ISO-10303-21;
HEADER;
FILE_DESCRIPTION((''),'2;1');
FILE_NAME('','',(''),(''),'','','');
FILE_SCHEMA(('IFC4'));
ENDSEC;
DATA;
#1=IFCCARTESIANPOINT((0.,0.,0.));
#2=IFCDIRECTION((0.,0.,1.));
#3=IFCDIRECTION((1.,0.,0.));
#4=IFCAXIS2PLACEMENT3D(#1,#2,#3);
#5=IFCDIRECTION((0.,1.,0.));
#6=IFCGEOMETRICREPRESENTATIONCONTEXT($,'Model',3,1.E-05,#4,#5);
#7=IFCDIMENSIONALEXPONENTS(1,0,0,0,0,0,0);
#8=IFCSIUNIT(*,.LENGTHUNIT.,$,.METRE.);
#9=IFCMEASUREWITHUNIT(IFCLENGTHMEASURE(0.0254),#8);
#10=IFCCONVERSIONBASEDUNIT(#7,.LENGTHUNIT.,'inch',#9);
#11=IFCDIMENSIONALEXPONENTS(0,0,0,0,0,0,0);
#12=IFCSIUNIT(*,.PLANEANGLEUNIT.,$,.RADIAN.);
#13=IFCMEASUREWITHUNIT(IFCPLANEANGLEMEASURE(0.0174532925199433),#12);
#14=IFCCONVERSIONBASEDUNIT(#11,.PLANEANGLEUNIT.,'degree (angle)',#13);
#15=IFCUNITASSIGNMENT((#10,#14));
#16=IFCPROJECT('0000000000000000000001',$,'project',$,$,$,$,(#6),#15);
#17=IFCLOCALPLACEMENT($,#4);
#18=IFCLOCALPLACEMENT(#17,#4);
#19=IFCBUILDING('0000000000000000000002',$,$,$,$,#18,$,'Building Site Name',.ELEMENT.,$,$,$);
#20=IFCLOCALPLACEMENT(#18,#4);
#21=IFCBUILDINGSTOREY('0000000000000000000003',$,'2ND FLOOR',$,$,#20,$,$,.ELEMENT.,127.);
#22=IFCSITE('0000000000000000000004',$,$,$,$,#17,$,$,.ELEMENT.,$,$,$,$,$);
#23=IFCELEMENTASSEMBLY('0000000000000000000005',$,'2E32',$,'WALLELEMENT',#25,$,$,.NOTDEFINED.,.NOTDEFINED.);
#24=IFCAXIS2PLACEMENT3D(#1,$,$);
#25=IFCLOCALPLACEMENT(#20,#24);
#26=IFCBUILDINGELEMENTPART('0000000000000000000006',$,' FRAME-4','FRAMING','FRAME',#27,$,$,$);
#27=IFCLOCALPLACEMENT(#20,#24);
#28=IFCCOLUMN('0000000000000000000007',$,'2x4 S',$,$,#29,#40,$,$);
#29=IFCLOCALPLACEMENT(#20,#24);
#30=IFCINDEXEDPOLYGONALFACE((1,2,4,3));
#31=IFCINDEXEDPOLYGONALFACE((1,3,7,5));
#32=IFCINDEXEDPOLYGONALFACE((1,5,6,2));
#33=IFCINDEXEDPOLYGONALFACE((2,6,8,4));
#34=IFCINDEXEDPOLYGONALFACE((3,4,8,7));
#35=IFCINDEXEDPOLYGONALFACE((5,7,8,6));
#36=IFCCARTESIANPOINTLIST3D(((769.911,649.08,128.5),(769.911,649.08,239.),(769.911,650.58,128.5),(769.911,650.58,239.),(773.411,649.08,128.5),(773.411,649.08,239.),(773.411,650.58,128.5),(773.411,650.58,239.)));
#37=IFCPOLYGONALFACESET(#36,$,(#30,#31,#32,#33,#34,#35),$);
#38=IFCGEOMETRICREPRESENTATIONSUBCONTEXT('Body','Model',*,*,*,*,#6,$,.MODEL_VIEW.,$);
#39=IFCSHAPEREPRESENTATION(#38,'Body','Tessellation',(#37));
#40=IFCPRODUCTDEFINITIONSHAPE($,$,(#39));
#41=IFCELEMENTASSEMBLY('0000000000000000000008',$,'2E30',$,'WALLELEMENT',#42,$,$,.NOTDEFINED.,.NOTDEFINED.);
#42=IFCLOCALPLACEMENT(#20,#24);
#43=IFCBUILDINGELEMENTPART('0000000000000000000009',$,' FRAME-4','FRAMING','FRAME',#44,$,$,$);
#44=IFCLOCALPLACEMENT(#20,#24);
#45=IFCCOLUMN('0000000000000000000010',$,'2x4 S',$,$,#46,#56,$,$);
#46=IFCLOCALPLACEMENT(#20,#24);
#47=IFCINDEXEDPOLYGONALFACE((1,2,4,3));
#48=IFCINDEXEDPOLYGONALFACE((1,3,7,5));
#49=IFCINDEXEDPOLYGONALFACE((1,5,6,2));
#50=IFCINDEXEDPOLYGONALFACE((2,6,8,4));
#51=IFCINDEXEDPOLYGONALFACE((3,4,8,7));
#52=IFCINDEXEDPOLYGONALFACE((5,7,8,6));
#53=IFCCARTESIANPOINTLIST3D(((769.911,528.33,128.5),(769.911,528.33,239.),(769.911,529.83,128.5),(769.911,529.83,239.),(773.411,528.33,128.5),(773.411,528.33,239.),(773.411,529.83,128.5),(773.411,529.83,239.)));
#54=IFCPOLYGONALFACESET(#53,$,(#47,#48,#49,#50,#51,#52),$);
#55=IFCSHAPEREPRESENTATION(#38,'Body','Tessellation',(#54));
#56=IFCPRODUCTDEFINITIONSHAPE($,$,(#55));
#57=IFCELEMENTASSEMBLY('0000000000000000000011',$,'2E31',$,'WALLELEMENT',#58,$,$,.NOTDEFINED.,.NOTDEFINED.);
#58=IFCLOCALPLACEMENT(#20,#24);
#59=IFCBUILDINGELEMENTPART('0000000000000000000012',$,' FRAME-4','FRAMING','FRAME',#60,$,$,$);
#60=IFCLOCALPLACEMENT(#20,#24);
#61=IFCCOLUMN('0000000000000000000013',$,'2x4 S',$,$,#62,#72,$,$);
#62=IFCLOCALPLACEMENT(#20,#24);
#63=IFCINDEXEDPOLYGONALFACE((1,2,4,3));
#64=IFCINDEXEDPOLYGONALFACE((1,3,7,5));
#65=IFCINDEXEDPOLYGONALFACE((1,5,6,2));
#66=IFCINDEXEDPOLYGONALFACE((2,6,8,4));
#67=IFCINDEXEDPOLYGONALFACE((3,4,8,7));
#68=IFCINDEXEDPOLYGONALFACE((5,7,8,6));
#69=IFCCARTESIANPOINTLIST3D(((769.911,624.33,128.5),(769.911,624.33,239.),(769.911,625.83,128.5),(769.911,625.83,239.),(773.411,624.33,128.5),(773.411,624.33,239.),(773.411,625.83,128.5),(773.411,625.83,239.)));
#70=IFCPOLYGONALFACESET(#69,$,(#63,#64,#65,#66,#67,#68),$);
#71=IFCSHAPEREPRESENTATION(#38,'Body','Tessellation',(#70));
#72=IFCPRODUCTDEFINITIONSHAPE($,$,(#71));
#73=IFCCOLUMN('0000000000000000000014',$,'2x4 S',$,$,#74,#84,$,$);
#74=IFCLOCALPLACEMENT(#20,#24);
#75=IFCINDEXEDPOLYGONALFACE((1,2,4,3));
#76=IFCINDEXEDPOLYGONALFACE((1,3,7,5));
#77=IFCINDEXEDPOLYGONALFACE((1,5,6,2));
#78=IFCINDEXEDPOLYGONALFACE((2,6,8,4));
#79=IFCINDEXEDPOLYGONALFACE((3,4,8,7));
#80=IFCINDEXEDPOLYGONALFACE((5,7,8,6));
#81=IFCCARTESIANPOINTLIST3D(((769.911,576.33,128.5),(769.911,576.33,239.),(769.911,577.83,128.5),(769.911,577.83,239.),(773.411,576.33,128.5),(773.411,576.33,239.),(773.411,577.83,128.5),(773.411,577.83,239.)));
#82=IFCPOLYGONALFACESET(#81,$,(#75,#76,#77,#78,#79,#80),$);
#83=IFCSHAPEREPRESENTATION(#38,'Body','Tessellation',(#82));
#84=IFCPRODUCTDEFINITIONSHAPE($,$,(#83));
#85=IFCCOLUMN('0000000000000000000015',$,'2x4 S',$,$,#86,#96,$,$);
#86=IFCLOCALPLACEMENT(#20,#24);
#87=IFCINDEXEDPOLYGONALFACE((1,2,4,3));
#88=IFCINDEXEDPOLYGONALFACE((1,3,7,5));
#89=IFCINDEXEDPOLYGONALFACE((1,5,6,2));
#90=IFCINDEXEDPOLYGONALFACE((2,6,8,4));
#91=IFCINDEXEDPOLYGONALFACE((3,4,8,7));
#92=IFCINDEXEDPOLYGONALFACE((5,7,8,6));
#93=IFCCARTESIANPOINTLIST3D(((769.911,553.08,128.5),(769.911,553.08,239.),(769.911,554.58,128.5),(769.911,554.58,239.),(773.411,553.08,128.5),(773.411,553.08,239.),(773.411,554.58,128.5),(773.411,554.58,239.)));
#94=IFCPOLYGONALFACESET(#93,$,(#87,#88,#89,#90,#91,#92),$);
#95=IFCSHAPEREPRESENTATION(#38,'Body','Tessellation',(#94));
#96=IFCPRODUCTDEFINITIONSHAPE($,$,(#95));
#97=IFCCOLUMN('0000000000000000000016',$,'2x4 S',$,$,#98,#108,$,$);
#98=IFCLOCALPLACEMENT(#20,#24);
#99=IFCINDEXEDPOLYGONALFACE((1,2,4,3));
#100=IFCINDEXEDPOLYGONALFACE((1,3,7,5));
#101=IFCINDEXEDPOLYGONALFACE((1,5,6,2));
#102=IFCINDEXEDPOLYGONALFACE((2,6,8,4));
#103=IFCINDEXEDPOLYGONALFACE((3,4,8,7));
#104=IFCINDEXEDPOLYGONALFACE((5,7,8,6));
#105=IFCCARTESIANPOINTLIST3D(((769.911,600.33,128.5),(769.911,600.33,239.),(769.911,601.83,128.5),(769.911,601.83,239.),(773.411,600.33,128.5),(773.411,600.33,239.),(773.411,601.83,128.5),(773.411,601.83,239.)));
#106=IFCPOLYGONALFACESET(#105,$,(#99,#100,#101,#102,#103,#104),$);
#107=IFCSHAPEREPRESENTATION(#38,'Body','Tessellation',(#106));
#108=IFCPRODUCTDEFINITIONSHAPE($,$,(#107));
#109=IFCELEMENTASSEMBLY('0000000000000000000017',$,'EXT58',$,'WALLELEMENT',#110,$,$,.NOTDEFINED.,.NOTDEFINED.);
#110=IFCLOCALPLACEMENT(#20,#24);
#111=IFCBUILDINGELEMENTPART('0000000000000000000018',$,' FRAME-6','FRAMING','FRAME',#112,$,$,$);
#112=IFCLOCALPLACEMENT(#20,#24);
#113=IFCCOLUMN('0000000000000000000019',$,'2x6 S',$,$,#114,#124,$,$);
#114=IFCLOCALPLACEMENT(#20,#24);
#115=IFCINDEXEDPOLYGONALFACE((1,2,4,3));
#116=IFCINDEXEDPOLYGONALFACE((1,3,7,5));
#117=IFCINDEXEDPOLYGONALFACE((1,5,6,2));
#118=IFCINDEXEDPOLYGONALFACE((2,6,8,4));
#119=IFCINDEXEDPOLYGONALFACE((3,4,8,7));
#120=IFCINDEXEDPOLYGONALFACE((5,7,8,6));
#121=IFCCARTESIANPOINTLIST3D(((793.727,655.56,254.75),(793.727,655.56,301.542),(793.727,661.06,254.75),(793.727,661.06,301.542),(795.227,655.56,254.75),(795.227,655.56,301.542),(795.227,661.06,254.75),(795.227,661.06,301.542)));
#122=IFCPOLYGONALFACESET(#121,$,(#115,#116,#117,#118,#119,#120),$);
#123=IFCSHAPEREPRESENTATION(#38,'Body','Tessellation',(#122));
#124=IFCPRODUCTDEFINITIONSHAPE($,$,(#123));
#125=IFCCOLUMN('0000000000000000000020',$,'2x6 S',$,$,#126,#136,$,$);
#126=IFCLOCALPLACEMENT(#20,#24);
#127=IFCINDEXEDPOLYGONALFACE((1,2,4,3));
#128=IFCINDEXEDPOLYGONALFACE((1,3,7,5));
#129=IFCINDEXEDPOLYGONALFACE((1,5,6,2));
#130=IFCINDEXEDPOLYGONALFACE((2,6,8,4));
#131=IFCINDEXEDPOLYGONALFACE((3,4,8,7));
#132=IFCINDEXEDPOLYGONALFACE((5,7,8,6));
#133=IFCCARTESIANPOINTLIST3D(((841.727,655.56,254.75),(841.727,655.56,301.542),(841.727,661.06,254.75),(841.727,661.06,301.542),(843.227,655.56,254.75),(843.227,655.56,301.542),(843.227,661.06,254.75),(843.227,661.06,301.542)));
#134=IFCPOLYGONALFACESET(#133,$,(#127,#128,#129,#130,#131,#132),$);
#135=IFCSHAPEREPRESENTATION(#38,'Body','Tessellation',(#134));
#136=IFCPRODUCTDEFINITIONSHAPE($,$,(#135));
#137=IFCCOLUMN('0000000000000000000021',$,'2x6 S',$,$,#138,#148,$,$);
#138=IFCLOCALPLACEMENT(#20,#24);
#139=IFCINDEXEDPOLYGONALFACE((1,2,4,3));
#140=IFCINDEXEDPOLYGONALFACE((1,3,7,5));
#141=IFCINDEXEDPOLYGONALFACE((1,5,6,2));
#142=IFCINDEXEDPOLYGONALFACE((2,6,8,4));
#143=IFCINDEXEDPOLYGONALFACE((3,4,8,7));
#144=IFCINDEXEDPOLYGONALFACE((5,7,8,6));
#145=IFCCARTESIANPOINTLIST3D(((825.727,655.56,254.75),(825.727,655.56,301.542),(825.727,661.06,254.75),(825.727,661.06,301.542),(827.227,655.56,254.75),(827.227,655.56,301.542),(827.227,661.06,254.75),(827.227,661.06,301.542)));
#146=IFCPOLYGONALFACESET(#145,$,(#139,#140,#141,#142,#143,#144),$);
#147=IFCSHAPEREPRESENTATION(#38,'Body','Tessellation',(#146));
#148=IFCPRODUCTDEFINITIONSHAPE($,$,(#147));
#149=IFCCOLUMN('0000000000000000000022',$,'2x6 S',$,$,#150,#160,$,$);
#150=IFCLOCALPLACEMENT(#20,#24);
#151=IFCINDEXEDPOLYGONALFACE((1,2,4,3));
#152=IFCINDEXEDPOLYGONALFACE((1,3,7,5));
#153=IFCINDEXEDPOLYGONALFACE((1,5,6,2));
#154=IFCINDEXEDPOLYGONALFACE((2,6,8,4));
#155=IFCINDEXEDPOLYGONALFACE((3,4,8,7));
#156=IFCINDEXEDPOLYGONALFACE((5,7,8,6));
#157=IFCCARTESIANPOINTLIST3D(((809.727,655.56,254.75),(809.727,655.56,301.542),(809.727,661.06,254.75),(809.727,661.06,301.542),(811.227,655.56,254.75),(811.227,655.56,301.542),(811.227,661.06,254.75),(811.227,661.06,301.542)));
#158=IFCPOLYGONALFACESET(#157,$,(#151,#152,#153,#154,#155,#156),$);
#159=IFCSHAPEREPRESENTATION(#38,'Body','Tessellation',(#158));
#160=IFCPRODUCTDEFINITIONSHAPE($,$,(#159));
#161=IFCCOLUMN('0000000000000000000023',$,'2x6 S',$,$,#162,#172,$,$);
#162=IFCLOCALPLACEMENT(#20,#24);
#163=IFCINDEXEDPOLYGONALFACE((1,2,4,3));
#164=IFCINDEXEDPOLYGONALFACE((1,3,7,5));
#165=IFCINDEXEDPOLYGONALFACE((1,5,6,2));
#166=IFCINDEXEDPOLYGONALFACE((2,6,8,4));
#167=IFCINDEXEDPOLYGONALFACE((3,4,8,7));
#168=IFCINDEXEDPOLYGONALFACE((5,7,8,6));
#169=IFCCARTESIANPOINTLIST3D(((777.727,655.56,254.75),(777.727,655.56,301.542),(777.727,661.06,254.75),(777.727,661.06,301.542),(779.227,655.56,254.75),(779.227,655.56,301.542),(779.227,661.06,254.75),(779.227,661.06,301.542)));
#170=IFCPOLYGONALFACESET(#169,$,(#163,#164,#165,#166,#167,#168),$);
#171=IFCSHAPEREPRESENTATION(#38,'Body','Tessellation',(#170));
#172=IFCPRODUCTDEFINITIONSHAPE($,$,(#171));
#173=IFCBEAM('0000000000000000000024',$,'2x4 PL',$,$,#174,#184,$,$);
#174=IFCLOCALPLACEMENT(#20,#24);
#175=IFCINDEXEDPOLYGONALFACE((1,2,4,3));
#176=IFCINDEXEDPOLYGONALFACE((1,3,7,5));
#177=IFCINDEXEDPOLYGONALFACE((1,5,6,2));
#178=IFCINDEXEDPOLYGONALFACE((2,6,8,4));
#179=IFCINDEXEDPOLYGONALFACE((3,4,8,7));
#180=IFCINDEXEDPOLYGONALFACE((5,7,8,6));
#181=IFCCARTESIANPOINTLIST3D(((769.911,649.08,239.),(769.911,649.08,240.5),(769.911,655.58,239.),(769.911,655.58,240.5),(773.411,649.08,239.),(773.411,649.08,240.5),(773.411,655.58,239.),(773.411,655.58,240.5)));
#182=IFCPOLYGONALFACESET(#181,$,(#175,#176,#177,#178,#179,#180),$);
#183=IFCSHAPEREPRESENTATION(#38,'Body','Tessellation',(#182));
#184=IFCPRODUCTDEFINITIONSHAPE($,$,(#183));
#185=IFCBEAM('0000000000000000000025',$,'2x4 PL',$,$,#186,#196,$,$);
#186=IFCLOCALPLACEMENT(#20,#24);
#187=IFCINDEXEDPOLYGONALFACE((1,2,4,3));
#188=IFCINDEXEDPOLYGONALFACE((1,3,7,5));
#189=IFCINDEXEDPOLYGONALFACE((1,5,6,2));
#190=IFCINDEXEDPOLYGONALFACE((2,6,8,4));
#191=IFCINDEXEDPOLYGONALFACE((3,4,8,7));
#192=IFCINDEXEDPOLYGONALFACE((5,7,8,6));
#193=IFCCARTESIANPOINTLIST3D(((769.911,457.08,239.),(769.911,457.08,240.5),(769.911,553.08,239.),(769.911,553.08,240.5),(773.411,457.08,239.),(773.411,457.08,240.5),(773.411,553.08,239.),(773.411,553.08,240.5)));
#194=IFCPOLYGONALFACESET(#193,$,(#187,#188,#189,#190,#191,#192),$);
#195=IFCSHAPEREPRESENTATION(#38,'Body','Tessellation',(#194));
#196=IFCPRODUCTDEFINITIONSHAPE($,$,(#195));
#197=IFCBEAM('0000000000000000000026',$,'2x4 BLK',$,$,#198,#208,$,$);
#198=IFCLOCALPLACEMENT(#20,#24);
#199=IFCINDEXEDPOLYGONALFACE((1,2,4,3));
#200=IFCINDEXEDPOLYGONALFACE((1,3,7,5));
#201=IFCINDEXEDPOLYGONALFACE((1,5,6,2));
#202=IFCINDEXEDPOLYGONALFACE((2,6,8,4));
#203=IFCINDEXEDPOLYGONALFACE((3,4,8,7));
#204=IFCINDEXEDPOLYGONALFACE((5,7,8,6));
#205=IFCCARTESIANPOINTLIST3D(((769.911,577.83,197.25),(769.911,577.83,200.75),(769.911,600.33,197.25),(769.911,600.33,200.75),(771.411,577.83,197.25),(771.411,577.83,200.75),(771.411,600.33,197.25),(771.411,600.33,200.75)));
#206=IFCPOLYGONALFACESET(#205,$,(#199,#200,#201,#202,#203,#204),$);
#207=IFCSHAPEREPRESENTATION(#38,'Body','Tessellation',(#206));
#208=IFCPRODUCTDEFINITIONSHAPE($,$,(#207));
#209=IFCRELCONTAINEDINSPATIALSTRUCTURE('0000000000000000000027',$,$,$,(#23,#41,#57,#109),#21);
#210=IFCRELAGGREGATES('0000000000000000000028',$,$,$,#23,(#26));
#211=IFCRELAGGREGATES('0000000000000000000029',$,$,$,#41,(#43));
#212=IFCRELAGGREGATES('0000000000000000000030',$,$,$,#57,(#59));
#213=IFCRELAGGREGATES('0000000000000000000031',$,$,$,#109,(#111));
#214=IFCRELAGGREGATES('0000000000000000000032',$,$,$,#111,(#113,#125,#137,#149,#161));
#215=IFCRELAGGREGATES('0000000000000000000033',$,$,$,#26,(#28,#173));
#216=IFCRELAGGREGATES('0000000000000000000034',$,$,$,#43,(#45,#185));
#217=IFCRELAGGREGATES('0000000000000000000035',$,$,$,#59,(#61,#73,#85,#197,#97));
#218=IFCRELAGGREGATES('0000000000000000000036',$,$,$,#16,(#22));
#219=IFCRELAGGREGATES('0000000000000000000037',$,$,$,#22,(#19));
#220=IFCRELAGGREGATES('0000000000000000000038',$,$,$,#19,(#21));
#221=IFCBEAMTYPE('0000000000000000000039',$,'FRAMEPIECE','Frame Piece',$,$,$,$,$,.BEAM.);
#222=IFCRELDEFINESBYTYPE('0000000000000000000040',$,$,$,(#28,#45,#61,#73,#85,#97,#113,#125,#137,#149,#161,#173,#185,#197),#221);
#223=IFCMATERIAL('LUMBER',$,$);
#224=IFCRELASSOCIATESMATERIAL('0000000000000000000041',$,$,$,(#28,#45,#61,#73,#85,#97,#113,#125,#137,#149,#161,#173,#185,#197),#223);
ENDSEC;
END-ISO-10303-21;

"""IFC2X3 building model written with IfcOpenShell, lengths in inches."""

from ifc_helpers import new_model, entity, si_unit, converted_unit, direction, frame, frame_2d, origin_with_axes, place, context, subcontext, project, spatial, rectangle, extrude, material, type_object, element, aggregate, save


model = new_model("IFC2X3")

# Units and contexts
model_context = context("Model", 3, precision=1e-05, world=origin_with_axes(), true_north=direction((0.0, 1.0, 0.0)))
body_context = subcontext(model_context, "Body", "Model", "MODEL_VIEW")
ifc_project = project(units=[converted_unit("LENGTHUNIT", "inch", entity("IfcLengthMeasure", 0.0254), si_unit("LENGTHUNIT", "METRE"), dimensions=[1, 0, 0, 0, 0, 0, 0]), converted_unit("PLANEANGLEUNIT", "degree (angle)", entity("IfcPlaneAngleMeasure", 0.0174532925199433), si_unit("PLANEANGLEUNIT", "RADIAN"), dimensions=[0, 0, 0, 0, 0, 0, 0])], contexts=[model_context])

# Site, building, storey
site_placement = place(None, origin_with_axes())
site = spatial("IfcSite", under=ifc_project, at=site_placement, CompositionType="ELEMENT")
building_placement = place(site_placement, origin_with_axes())
building = spatial("IfcBuilding", under=site, at=building_placement, LongName="Building Site Name", CompositionType="ELEMENT")
storey_placement = place(building_placement, origin_with_axes())
storey = spatial("IfcBuildingStorey", under=building, at=storey_placement, Name="2ND FLOOR", CompositionType="ELEMENT", Elevation=127.0)

# Element assemblies, building element parts, columns
assembly_1_placement = place(storey_placement, origin_with_axes())
assembly_1 = element("IfcElementAssembly", 1, at=assembly_1_placement, inside=storey, Name="2E32", ObjectType="WALLELEMENT", AssemblyPlace="NOTDEFINED", PredefinedType="NOTDEFINED")
building_element_part_1 = element("IfcBuildingElementPart", 2, Name=" FRAME-4", Description="FRAMING", ObjectType="FRAME")
aggregate(assembly_1, [building_element_part_1])
ifc_material = material(Name="LUMBER")
beam_type = type_object("IfcBeamType", Name="FRAMEPIECE", Description="Frame Piece", PredefinedType="BEAM")
column_1_placement = place(assembly_1_placement, frame((771.661, 649.83, 239.0), z_axis=(0.0, 0.0, -1.0), x_axis=(0.0, 1.0, 0.0)))
column_1 = element("IfcColumn", 3, at=column_1_placement, type_object=beam_type, material=ifc_material, Name="2x4 S", context=body_context, shape_type="SweptSolid", body=[
    extrude(rectangle(XDim=1.5, YDim=3.5, at=frame_2d((0.0, 0.0), x_axis=(-1.0, 0.0))), origin_with_axes(), (0.0, 0.0, 1.0), 110.5),
])
assembly_2_placement = place(storey_placement, origin_with_axes())
assembly_2 = element("IfcElementAssembly", 4, at=assembly_2_placement, inside=storey, Name="2E30", ObjectType="WALLELEMENT", AssemblyPlace="NOTDEFINED", PredefinedType="NOTDEFINED")
building_element_part_2 = element("IfcBuildingElementPart", 5, Name=" FRAME-4", Description="FRAMING", ObjectType="FRAME")
aggregate(assembly_2, [building_element_part_2])
column_2_placement = place(assembly_2_placement, frame((771.661, 529.08, 239.0), z_axis=(0.0, 0.0, -1.0), x_axis=(0.0, 1.0, 0.0)))
column_2 = element("IfcColumn", 6, at=column_2_placement, type_object=beam_type, material=ifc_material, Name="2x4 S", context=body_context, shape_type="SweptSolid", body=[
    extrude(rectangle(XDim=1.5, YDim=3.5, at=frame_2d((0.0, 0.0), x_axis=(-1.0, 0.0))), origin_with_axes(), (0.0, 0.0, 1.0), 110.5),
])

# Element assemblies, building element parts, columns
assembly_3_placement = place(storey_placement, origin_with_axes())
assembly_3 = element("IfcElementAssembly", 7, at=assembly_3_placement, inside=storey, Name="2E31", ObjectType="WALLELEMENT", AssemblyPlace="NOTDEFINED", PredefinedType="NOTDEFINED")
building_element_part_3 = element("IfcBuildingElementPart", 8, Name=" FRAME-4", Description="FRAMING", ObjectType="FRAME")
aggregate(assembly_3, [building_element_part_3])
column_3_placement = place(assembly_3_placement, frame((771.661, 625.08, 239.0), z_axis=(0.0, 0.0, -1.0), x_axis=(0.0, 1.0, 0.0)))
column_3 = element("IfcColumn", 9, at=column_3_placement, type_object=beam_type, material=ifc_material, Name="2x4 S", context=body_context, shape_type="SweptSolid", body=[
    extrude(rectangle(XDim=1.5, YDim=3.5, at=frame_2d((0.0, 0.0), x_axis=(-1.0, 0.0))), origin_with_axes(), (0.0, 0.0, 1.0), 110.5),
])
column_4_placement = place(assembly_3_placement, frame((771.661, 577.08, 239.0), z_axis=(0.0, 0.0, -1.0), x_axis=(0.0, 1.0, 0.0)))
column_4 = element("IfcColumn", 10, at=column_4_placement, type_object=beam_type, material=ifc_material, Name="2x4 S", context=body_context, shape_type="SweptSolid", body=[
    extrude(rectangle(XDim=1.5, YDim=3.5, at=frame_2d((0.0, 0.0), x_axis=(-1.0, 0.0))), origin_with_axes(), (0.0, 0.0, 1.0), 110.5),
])
column_5_placement = place(assembly_3_placement, frame((771.661, 553.83, 239.0), z_axis=(0.0, 0.0, -1.0), x_axis=(0.0, 1.0, 0.0)))
column_5 = element("IfcColumn", 11, at=column_5_placement, type_object=beam_type, material=ifc_material, Name="2x4 S", context=body_context, shape_type="SweptSolid", body=[
    extrude(rectangle(XDim=1.5, YDim=3.5, at=frame_2d((0.0, 0.0), x_axis=(-1.0, 0.0))), origin_with_axes(), (0.0, 0.0, 1.0), 110.5),
])
column_6_placement = place(assembly_3_placement, frame((771.661, 601.08, 239.0), z_axis=(0.0, 0.0, -1.0), x_axis=(0.0, 1.0, 0.0)))
column_6 = element("IfcColumn", 12, at=column_6_placement, type_object=beam_type, material=ifc_material, Name="2x4 S", context=body_context, shape_type="SweptSolid", body=[
    extrude(rectangle(XDim=1.5, YDim=3.5, at=frame_2d((0.0, 0.0), x_axis=(-1.0, 0.0))), origin_with_axes(), (0.0, 0.0, 1.0), 110.5),
])
assembly_4_placement = place(storey_placement, origin_with_axes())
assembly_4 = element("IfcElementAssembly", 13, at=assembly_4_placement, inside=storey, Name="EXT58", ObjectType="WALLELEMENT", AssemblyPlace="NOTDEFINED", PredefinedType="NOTDEFINED")
building_element_part_4 = element("IfcBuildingElementPart", 14, Name=" FRAME-6", Description="FRAMING", ObjectType="FRAME")
aggregate(assembly_4, [building_element_part_4])
column_7_placement = place(assembly_4_placement, frame((794.477, 658.31, 301.542), z_axis=(0.0, 0.0, -1.0), x_axis=(-1.0, 0.0, 0.0)))
column_7 = element("IfcColumn", 15, at=column_7_placement, type_object=beam_type, material=ifc_material, Name="2x6 S", context=body_context, shape_type="SweptSolid", body=[
    extrude(rectangle(XDim=1.5, YDim=5.5, at=frame_2d((0.0, 0.0), x_axis=(-1.0, 0.0))), origin_with_axes(), (0.0, 0.0, 1.0), 46.792),
])
column_8_placement = place(assembly_4_placement, frame((842.477, 658.31, 301.542), z_axis=(0.0, 0.0, -1.0), x_axis=(-1.0, 0.0, 0.0)))
column_8 = element("IfcColumn", 16, at=column_8_placement, type_object=beam_type, material=ifc_material, Name="2x6 S", context=body_context, shape_type="SweptSolid", body=[
    extrude(rectangle(XDim=1.5, YDim=5.5, at=frame_2d((0.0, 0.0), x_axis=(-1.0, 0.0))), origin_with_axes(), (0.0, 0.0, 1.0), 46.792),
])
column_9_placement = place(assembly_4_placement, frame((826.477, 658.31, 301.542), z_axis=(0.0, 0.0, -1.0), x_axis=(-1.0, 0.0, 0.0)))
column_9 = element("IfcColumn", 17, at=column_9_placement, type_object=beam_type, material=ifc_material, Name="2x6 S", context=body_context, shape_type="SweptSolid", body=[
    extrude(rectangle(XDim=1.5, YDim=5.5, at=frame_2d((0.0, 0.0), x_axis=(-1.0, 0.0))), origin_with_axes(), (0.0, 0.0, 1.0), 46.792),
])
column_10_placement = place(assembly_4_placement, frame((810.477, 658.31, 301.542), z_axis=(0.0, 0.0, -1.0), x_axis=(-1.0, 0.0, 0.0)))
column_10 = element("IfcColumn", 18, at=column_10_placement, type_object=beam_type, material=ifc_material, Name="2x6 S", context=body_context, shape_type="SweptSolid", body=[
    extrude(rectangle(XDim=1.5, YDim=5.5, at=frame_2d((0.0, 0.0), x_axis=(-1.0, 0.0))), origin_with_axes(), (0.0, 0.0, 1.0), 46.792),
])
column_11_placement = place(assembly_4_placement, frame((778.477, 658.31, 301.542), z_axis=(0.0, 0.0, -1.0), x_axis=(-1.0, 0.0, 0.0)))
column_11 = element("IfcColumn", 19, at=column_11_placement, type_object=beam_type, material=ifc_material, Name="2x6 S", context=body_context, shape_type="SweptSolid", body=[
    extrude(rectangle(XDim=1.5, YDim=5.5, at=frame_2d((0.0, 0.0), x_axis=(-1.0, 0.0))), origin_with_axes(), (0.0, 0.0, 1.0), 46.792),
])
aggregate(building_element_part_4, [column_7, column_8, column_9, column_10, column_11])

# Beams
beam_1_placement = place(assembly_1_placement, frame((771.661, 655.58, 239.75), z_axis=(0.0, -1.0, 0.0), x_axis=(0.0, 0.0, -1.0)))
beam_1 = element("IfcBeam", 20, at=beam_1_placement, type_object=beam_type, material=ifc_material, Name="2x4 PL", context=body_context, shape_type="SweptSolid", body=[
    extrude(rectangle(XDim=1.5, YDim=3.5, at=frame_2d((0.0, 0.0), x_axis=(-1.0, 0.0))), origin_with_axes(), (0.0, 0.0, 1.0), 6.5),
])
aggregate(building_element_part_1, [column_1, beam_1])
beam_2_placement = place(assembly_2_placement, frame((771.661, 553.08, 239.75), z_axis=(0.0, -1.0, 0.0), x_axis=(0.0, 0.0, -1.0)))
beam_2 = element("IfcBeam", 21, at=beam_2_placement, type_object=beam_type, material=ifc_material, Name="2x4 PL", context=body_context, shape_type="SweptSolid", body=[
    extrude(rectangle(XDim=1.5, YDim=3.5, at=frame_2d((0.0, 0.0), x_axis=(-1.0, 0.0))), origin_with_axes(), (0.0, 0.0, 1.0), 96.0),
])
aggregate(building_element_part_2, [column_2, beam_2])
beam_3_placement = place(assembly_3_placement, frame((770.661, 600.33, 199.0), z_axis=(0.0, -1.0, 0.0), x_axis=(-1.0, 0.0, 0.0)))
beam_3 = element("IfcBeam", 22, at=beam_3_placement, type_object=beam_type, material=ifc_material, Name="2x4 BLK", context=body_context, shape_type="SweptSolid", body=[
    extrude(rectangle(XDim=1.5, YDim=3.5, at=frame_2d((0.0, 0.0), x_axis=(-1.0, 0.0))), origin_with_axes(), (0.0, 0.0, 1.0), 22.5),
])
aggregate(building_element_part_3, [column_3, column_4, column_5, beam_3, column_6])

save(model, "model.ifc")
